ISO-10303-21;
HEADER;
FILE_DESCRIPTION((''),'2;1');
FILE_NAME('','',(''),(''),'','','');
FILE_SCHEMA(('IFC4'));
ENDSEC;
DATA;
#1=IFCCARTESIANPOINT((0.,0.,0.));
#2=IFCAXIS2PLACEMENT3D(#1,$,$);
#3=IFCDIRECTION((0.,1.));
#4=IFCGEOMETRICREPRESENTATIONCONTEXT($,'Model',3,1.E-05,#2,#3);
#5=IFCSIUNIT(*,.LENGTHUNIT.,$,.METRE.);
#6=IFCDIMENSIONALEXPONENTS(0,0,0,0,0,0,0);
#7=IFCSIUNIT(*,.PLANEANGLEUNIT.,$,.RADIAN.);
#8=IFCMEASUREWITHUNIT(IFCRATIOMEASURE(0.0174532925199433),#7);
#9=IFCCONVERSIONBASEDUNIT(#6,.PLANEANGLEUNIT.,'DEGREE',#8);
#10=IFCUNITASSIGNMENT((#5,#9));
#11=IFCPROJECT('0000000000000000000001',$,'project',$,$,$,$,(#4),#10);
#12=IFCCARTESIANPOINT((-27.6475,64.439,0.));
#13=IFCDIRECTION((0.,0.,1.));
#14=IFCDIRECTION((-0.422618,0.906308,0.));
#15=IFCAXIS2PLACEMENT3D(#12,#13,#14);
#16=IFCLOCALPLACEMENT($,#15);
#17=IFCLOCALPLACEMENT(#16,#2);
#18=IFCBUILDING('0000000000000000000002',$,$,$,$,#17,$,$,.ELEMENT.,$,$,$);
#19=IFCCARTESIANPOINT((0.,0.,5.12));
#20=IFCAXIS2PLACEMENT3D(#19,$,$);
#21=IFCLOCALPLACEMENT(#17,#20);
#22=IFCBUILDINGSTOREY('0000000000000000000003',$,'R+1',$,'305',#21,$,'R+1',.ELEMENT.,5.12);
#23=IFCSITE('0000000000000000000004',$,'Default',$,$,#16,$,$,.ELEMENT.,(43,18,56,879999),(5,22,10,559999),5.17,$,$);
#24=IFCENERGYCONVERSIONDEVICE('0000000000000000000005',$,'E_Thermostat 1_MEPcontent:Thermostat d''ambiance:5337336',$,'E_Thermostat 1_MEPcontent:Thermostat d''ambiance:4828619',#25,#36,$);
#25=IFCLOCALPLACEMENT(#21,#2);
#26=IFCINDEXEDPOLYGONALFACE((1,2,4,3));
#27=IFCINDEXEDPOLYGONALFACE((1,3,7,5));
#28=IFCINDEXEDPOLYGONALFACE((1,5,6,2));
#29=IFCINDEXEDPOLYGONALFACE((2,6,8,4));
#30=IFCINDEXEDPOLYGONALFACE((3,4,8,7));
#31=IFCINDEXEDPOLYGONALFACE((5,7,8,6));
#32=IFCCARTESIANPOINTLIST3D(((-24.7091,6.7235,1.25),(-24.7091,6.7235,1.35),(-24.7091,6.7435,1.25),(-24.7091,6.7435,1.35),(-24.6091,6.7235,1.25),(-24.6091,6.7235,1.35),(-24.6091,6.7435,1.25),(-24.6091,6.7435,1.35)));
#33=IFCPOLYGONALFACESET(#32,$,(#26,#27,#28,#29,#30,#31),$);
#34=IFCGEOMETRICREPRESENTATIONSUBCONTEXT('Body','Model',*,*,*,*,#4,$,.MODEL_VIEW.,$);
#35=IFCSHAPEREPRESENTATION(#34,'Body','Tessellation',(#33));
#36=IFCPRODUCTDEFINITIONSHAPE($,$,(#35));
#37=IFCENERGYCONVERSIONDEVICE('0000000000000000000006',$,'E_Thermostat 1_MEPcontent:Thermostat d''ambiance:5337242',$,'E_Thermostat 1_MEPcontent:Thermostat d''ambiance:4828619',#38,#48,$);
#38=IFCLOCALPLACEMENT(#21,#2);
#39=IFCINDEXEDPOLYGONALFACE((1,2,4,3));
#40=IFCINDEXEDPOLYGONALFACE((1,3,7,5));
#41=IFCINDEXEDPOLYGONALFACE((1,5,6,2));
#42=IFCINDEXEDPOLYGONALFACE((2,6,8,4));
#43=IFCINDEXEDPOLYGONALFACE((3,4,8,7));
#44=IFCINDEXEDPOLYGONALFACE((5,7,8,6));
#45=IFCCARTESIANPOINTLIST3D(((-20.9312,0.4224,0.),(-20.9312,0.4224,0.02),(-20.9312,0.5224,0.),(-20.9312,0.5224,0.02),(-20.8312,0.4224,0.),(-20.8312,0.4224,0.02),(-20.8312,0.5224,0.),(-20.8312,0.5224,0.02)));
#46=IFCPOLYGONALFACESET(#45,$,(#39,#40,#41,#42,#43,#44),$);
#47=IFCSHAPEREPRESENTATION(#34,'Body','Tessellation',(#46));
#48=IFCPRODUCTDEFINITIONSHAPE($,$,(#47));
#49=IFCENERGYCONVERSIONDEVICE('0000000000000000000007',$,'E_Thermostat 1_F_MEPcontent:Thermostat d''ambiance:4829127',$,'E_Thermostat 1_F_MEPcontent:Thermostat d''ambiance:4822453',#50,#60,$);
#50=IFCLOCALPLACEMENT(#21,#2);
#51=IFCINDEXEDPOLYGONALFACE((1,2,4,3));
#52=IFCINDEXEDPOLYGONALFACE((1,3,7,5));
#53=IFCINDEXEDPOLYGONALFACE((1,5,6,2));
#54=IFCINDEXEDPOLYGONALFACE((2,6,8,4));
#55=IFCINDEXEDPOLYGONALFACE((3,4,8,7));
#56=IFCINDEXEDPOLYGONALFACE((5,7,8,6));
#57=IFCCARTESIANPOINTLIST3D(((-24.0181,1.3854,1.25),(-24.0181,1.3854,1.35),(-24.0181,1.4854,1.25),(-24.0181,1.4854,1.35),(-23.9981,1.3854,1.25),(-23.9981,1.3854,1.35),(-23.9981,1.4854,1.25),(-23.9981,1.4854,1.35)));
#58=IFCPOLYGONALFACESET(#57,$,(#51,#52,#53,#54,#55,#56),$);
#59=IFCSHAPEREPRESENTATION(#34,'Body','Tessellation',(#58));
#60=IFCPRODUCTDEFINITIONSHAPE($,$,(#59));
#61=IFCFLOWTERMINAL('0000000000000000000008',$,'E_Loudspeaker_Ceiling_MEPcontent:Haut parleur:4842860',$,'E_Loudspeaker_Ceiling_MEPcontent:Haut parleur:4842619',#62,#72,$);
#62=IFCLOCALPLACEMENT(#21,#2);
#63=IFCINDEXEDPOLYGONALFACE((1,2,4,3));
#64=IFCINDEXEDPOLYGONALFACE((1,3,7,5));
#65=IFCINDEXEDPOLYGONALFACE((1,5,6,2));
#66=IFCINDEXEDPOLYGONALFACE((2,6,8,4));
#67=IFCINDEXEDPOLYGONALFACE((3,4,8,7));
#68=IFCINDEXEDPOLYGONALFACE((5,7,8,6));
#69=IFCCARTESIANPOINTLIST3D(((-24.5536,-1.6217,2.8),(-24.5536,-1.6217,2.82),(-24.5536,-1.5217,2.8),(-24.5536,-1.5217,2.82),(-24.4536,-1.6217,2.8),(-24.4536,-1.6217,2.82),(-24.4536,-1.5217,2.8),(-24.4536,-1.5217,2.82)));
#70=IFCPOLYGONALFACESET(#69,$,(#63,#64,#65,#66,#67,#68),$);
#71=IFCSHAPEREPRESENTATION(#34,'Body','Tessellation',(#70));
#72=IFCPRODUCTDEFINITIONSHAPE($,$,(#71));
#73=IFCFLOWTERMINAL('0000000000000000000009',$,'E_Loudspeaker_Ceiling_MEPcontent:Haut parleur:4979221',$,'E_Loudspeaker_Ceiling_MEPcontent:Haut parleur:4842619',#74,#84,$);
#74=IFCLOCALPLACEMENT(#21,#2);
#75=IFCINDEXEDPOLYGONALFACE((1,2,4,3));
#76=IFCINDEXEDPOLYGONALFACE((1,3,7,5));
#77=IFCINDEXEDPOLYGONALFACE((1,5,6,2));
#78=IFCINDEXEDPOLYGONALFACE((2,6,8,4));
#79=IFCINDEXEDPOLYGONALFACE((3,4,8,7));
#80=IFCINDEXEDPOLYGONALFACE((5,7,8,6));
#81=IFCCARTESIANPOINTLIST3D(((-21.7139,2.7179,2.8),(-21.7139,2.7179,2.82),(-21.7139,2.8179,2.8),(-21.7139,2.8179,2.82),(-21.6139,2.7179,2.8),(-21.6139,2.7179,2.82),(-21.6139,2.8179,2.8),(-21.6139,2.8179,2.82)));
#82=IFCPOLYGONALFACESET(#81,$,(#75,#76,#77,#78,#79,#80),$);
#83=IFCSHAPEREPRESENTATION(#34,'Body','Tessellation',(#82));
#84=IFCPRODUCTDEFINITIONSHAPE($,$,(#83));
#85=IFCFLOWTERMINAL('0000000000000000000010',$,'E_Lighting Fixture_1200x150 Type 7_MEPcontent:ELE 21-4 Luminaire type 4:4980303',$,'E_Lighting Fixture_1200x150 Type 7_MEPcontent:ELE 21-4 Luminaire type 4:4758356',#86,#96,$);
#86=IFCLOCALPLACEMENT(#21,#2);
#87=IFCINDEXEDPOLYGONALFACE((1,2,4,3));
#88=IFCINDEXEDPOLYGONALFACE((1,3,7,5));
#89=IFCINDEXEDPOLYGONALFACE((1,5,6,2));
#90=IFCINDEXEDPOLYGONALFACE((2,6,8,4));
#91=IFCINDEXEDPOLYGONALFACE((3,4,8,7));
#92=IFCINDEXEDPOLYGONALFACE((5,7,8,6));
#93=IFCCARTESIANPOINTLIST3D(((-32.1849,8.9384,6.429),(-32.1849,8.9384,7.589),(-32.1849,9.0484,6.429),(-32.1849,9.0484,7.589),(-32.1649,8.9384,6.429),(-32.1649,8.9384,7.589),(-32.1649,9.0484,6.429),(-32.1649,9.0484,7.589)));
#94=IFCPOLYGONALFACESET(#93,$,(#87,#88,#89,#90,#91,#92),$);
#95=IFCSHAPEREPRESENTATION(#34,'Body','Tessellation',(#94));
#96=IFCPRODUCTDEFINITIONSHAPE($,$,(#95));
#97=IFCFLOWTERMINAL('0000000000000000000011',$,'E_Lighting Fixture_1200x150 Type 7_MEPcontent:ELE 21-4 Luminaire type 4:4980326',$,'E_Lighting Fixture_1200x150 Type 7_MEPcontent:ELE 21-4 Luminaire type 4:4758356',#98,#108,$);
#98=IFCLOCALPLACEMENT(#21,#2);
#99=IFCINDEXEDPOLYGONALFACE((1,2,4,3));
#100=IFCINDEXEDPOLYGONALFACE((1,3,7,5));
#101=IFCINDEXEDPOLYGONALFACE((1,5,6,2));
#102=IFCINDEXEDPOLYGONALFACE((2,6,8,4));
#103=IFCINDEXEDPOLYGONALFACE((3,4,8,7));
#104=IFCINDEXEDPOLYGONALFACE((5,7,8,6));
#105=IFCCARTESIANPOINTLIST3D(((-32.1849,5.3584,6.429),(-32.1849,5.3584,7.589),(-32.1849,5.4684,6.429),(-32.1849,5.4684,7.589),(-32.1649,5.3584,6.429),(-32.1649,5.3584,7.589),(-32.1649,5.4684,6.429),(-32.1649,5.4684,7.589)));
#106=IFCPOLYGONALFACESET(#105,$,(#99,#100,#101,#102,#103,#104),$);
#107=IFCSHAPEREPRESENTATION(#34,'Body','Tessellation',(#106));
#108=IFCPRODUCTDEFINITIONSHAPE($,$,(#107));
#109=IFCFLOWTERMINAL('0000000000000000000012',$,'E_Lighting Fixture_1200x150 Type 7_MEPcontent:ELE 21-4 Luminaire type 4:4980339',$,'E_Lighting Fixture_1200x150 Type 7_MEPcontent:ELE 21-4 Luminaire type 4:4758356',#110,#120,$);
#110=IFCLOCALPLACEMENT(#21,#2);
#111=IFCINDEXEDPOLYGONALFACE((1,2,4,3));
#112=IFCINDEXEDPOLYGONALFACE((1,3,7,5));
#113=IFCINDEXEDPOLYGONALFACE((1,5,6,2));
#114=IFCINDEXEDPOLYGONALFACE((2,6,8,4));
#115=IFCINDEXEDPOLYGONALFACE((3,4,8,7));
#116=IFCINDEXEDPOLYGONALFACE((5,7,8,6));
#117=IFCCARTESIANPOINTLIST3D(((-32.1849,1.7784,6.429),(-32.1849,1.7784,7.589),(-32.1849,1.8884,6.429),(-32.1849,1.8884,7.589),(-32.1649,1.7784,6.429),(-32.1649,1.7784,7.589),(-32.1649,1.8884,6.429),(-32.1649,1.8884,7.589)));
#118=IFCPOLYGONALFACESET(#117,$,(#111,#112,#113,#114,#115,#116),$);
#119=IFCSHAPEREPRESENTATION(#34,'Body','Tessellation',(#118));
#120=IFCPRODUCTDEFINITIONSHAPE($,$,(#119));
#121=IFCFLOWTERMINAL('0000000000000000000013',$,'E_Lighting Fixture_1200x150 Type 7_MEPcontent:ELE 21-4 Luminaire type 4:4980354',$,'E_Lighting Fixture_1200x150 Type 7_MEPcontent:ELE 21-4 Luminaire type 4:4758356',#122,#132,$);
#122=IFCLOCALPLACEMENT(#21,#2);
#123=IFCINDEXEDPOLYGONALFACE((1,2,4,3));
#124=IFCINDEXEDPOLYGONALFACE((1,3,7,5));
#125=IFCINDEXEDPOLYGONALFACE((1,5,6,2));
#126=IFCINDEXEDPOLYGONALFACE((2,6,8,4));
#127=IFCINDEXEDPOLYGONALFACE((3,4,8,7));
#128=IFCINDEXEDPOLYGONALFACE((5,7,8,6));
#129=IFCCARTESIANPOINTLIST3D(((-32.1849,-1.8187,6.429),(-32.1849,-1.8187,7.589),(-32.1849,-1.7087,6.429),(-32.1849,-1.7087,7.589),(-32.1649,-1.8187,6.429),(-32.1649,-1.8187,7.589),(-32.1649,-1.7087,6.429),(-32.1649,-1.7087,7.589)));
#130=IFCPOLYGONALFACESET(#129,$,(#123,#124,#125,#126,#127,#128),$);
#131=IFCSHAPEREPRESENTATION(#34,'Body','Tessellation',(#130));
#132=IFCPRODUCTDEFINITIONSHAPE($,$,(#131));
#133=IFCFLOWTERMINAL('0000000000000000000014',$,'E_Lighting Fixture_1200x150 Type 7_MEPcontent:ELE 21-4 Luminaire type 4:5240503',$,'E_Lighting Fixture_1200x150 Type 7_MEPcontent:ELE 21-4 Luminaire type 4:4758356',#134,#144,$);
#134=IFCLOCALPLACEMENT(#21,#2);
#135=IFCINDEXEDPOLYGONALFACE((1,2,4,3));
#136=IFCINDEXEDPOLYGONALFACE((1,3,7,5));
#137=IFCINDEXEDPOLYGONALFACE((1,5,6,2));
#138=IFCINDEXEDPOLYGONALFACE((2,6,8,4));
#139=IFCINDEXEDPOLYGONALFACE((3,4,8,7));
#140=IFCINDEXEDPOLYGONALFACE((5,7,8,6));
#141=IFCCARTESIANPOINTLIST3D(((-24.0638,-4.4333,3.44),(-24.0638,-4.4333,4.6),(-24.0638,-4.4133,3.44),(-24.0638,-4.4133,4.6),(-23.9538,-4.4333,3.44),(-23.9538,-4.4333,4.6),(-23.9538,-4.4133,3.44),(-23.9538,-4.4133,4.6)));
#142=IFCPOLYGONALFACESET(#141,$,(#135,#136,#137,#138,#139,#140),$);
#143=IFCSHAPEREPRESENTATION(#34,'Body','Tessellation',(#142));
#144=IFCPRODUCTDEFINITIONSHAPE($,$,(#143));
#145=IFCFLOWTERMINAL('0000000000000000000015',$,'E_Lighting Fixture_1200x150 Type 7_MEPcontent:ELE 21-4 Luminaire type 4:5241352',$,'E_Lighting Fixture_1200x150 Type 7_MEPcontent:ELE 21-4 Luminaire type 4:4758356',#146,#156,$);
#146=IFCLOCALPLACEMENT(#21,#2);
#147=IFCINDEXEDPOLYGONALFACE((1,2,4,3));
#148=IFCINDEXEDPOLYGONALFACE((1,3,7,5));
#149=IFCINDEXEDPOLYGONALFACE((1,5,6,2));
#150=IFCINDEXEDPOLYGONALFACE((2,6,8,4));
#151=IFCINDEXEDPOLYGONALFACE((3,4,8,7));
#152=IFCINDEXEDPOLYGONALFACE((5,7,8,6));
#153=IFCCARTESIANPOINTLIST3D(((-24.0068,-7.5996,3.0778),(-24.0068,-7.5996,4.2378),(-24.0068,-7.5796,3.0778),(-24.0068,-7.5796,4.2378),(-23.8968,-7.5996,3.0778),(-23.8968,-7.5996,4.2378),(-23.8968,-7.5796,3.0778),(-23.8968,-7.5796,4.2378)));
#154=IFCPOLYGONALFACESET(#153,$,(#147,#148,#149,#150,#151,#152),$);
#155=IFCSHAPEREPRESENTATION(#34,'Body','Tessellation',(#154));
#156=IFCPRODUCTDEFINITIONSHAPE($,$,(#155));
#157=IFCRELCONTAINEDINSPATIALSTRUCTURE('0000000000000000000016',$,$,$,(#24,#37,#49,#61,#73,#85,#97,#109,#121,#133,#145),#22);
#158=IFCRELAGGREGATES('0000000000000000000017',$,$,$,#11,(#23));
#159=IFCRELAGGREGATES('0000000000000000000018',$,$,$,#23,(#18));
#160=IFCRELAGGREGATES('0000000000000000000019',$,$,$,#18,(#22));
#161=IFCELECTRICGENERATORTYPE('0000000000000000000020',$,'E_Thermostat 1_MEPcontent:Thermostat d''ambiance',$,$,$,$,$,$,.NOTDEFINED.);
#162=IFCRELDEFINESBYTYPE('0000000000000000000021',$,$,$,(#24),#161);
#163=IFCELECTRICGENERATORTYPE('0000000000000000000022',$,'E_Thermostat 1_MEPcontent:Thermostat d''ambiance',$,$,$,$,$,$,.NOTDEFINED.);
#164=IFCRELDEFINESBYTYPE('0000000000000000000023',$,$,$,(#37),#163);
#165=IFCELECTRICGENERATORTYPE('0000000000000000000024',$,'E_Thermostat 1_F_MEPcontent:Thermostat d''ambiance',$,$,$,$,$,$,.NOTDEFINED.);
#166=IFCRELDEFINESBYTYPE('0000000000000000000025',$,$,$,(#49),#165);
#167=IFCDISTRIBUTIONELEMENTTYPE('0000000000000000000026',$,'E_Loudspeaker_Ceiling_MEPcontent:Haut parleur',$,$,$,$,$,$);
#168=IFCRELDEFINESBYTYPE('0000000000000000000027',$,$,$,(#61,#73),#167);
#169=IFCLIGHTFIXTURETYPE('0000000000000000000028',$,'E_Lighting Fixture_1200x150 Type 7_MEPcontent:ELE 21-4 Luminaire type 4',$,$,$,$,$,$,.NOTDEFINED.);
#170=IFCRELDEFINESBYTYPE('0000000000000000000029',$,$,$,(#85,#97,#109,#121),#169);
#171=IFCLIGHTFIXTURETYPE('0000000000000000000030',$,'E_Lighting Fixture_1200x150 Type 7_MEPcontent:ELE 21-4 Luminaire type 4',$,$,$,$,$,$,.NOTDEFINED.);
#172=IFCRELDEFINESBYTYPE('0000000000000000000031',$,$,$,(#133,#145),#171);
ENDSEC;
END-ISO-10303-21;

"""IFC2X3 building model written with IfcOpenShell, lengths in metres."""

from ifc_helpers import new_model, entity, si_unit, converted_unit, direction, frame, frame_2d, origin, origin_2d_with_axis, place, context, subcontext, project, spatial, rectangle, extrude, source, transform, mapped, type_object, type_shapes, element, save


model = new_model("IFC2X3")

# Units and contexts
model_context = context("Model", 3, precision=1e-05, world=origin(), true_north=direction((0.0, 1.0)))
body_context = subcontext(model_context, "Body", "Model", "MODEL_VIEW")
ifc_project = project(units=[si_unit("LENGTHUNIT", "METRE"), converted_unit("PLANEANGLEUNIT", "DEGREE", entity("IfcRatioMeasure", 0.0174532925199433), si_unit("PLANEANGLEUNIT", "RADIAN"), dimensions=[0, 0, 0, 0, 0, 0, 0])], contexts=[model_context])

# Site, building, storey
site_placement = place(None, frame((-27.6475, 64.439, 0.0), z_axis=(0.0, 0.0, 1.0), x_axis=(-0.422618, 0.906308, 0.0)))
site = spatial("IfcSite", under=ifc_project, at=site_placement, Name="Default", CompositionType="ELEMENT", RefLatitude=(43, 18, 56, 879999), RefLongitude=(5, 22, 10, 559999), RefElevation=5.17)
building_placement = place(site_placement, origin())
building = spatial("IfcBuilding", under=site, at=building_placement, CompositionType="ELEMENT")
storey_placement = place(building_placement, frame((0.0, 0.0, 5.12)))
storey = spatial("IfcBuildingStorey", under=building, at=storey_placement, Name="R+1", ObjectType="305", LongName="R+1", CompositionType="ELEMENT", Elevation=5.12)

# Energy conversion devices
electric_generator_type_1 = type_object("IfcElectricGeneratorType", Name="E_Thermostat 1_MEPcontent:Thermostat d'ambiance", PredefinedType="NOTDEFINED")
shared_shape_1 = source(origin(), body_context, "Body", "SweptSolid", [
    extrude(rectangle(XDim=0.02, YDim=0.1, at=frame_2d((0.0, 0.0), x_axis=(1.0, 0.0))), frame((0.0, 0.01, -0.05), z_axis=(0.0, 0.0, 1.0), x_axis=(0.0, -1.0, 0.0)), (0.0, 0.0, 1.0), 0.1),
])
type_shapes(electric_generator_type_1, [shared_shape_1])
energy_conversion_device_1_placement = place(storey_placement, frame((-24.6591, 6.7235, 1.3)))
element("IfcEnergyConversionDevice", 1, at=energy_conversion_device_1_placement, inside=storey, type_object=electric_generator_type_1, Name="E_Thermostat 1_MEPcontent:Thermostat d'ambiance:5337336", ObjectType="E_Thermostat 1_MEPcontent:Thermostat d'ambiance:4828619", context=body_context, shape_type="MappedRepresentation", body=[
    mapped(shared_shape_1, transform((0.0, 0.0, 0.0), scale=1.0)),
])
electric_generator_type_2 = type_object("IfcElectricGeneratorType", Name="E_Thermostat 1_MEPcontent:Thermostat d'ambiance", PredefinedType="NOTDEFINED")
shared_shape_2 = source(origin(), body_context, "Body", "SweptSolid", [
    extrude(rectangle(XDim=0.1, YDim=0.1, at=origin_2d_with_axis()), frame((0.0, 0.0, 0.0), z_axis=(0.0, 0.0, 1.0), x_axis=(0.0, -1.0, 0.0)), (0.0, 0.0, 1.0), 0.02),
])
type_shapes(electric_generator_type_2, [shared_shape_2])
energy_conversion_device_2_placement = place(storey_placement, frame((-20.8812, 0.4724, 0.0), z_axis=(0.0, 0.0, 1.0), x_axis=(-1.0, 0.0, 0.0)))
element("IfcEnergyConversionDevice", 2, at=energy_conversion_device_2_placement, inside=storey, type_object=electric_generator_type_2, Name="E_Thermostat 1_MEPcontent:Thermostat d'ambiance:5337242", ObjectType="E_Thermostat 1_MEPcontent:Thermostat d'ambiance:4828619", context=body_context, shape_type="MappedRepresentation", body=[
    mapped(shared_shape_2, transform((0.0, 0.0, 0.0), scale=1.0)),
])
electric_generator_type_3 = type_object("IfcElectricGeneratorType", Name="E_Thermostat 1_F_MEPcontent:Thermostat d'ambiance", PredefinedType="NOTDEFINED")
shared_shape_3 = source(origin(), body_context, "Body", "SweptSolid", [
    extrude(rectangle(XDim=0.1, YDim=0.1, at=origin_2d_with_axis()), frame((0.0, 0.0, 0.0), z_axis=(0.0, 0.0, 1.0), x_axis=(0.0, 1.0, 0.0)), (0.0, 0.0, 1.0), 0.02),
])
type_shapes(electric_generator_type_3, [shared_shape_3])
energy_conversion_device_3_placement = place(storey_placement, frame((-23.9981, 1.4354, 1.3), z_axis=(-1.0, 0.0, 0.0), x_axis=(0.0, -1.0, 0.0)))
element("IfcEnergyConversionDevice", 3, at=energy_conversion_device_3_placement, inside=storey, type_object=electric_generator_type_3, Name="E_Thermostat 1_F_MEPcontent:Thermostat d'ambiance:4829127", ObjectType="E_Thermostat 1_F_MEPcontent:Thermostat d'ambiance:4822453", context=body_context, shape_type="MappedRepresentation", body=[
    mapped(shared_shape_3, transform((0.0, 0.0, 0.0), scale=1.0)),
])

# Flow terminals
distribution_element_type_1 = type_object("IfcDistributionElementType", Name="E_Loudspeaker_Ceiling_MEPcontent:Haut parleur")
shared_shape_4 = source(origin(), body_context, "Body", "SweptSolid", [
    extrude(rectangle(XDim=0.1, YDim=0.1, at=origin_2d_with_axis()), frame((0.0, 0.0, 0.0), z_axis=(0.0, 0.0, 1.0), x_axis=(0.0, -1.0, 0.0)), (0.0, 0.0, 1.0), 0.02),
])
type_shapes(distribution_element_type_1, [shared_shape_4])
flow_terminal_1_placement = place(storey_placement, frame((-24.5036, -1.5717, 2.8)))
element("IfcFlowTerminal", 4, at=flow_terminal_1_placement, inside=storey, type_object=distribution_element_type_1, Name="E_Loudspeaker_Ceiling_MEPcontent:Haut parleur:4842860", ObjectType="E_Loudspeaker_Ceiling_MEPcontent:Haut parleur:4842619", context=body_context, shape_type="MappedRepresentation", body=[
    mapped(shared_shape_4, transform((0.0, 0.0, 0.0), scale=1.0)),
])
flow_terminal_2_placement = place(storey_placement, frame((-21.6639, 2.7679, 2.8), z_axis=(0.0, 0.0, 1.0), x_axis=(0.0, 1.0, 0.0)))
element("IfcFlowTerminal", 5, at=flow_terminal_2_placement, inside=storey, type_object=distribution_element_type_1, Name="E_Loudspeaker_Ceiling_MEPcontent:Haut parleur:4979221", ObjectType="E_Loudspeaker_Ceiling_MEPcontent:Haut parleur:4842619", context=body_context, shape_type="MappedRepresentation", body=[
    mapped(shared_shape_4, transform((0.0, 0.0, 0.0), scale=1.0)),
])
light_fixture_type_1 = type_object("IfcLightFixtureType", Name="E_Lighting Fixture_1200x150 Type 7_MEPcontent:ELE 21-4 Luminaire type 4", PredefinedType="NOTDEFINED")
shared_shape_5 = source(origin(), body_context, "Body", "SweptSolid", [
    extrude(rectangle(XDim=0.02, YDim=0.11, at=frame_2d((0.0, 0.0), x_axis=(1.0, 0.0))), frame((0.01, 0.0, -0.58), z_axis=(0.0, 0.0, 1.0), x_axis=(-1.0, 0.0, 0.0)), (0.0, 0.0, 1.0), 1.16),
])
type_shapes(light_fixture_type_1, [shared_shape_5])
for number, where, name in (
    (6, (-32.1849, 8.9934, 7.009), "E_Lighting Fixture_1200x150 Type 7_MEPcontent:ELE 21-4 Luminaire type 4:4980303"),
    (7, (-32.1849, 5.4134, 7.009), "E_Lighting Fixture_1200x150 Type 7_MEPcontent:ELE 21-4 Luminaire type 4:4980326"),
    (8, (-32.1849, 1.8334, 7.009), "E_Lighting Fixture_1200x150 Type 7_MEPcontent:ELE 21-4 Luminaire type 4:4980339"),
    (9, (-32.1849, -1.7637, 7.009), "E_Lighting Fixture_1200x150 Type 7_MEPcontent:ELE 21-4 Luminaire type 4:4980354"),
):
    element("IfcFlowTerminal", number, at=place(storey_placement, frame(where)), inside=storey, type_object=light_fixture_type_1, Name=name, ObjectType="E_Lighting Fixture_1200x150 Type 7_MEPcontent:ELE 21-4 Luminaire type 4:4758356", context=body_context, shape_type="MappedRepresentation", body=[
        mapped(shared_shape_5, transform((0.0, 0.0, 0.0), scale=1.0)),
    ])
light_fixture_type_2 = type_object("IfcLightFixtureType", Name="E_Lighting Fixture_1200x150 Type 7_MEPcontent:ELE 21-4 Luminaire type 4", PredefinedType="NOTDEFINED")
shared_shape_6 = source(origin(), body_context, "Body", "SweptSolid", [
    extrude(rectangle(XDim=0.02, YDim=0.11, at=frame_2d((0.0, 0.0), x_axis=(1.0, 0.0))), frame((0.0, 0.01, -0.58), z_axis=(0.0, 0.0, 1.0), x_axis=(0.0, -1.0, 0.0)), (0.0, 0.0, 1.0), 1.16),
])
type_shapes(light_fixture_type_2, [shared_shape_6])
for number, where, name in (
    (10, (-24.0088, -4.4333, 4.02), "E_Lighting Fixture_1200x150 Type 7_MEPcontent:ELE 21-4 Luminaire type 4:5240503"),
    (11, (-23.9518, -7.5996, 3.6578), "E_Lighting Fixture_1200x150 Type 7_MEPcontent:ELE 21-4 Luminaire type 4:5241352"),
):
    element("IfcFlowTerminal", number, at=place(storey_placement, frame(where)), inside=storey, type_object=light_fixture_type_2, Name=name, ObjectType="E_Lighting Fixture_1200x150 Type 7_MEPcontent:ELE 21-4 Luminaire type 4:4758356", context=body_context, shape_type="MappedRepresentation", body=[
        mapped(shared_shape_6, transform((0.0, 0.0, 0.0), scale=1.0)),
    ])

save(model, "model.ifc")
